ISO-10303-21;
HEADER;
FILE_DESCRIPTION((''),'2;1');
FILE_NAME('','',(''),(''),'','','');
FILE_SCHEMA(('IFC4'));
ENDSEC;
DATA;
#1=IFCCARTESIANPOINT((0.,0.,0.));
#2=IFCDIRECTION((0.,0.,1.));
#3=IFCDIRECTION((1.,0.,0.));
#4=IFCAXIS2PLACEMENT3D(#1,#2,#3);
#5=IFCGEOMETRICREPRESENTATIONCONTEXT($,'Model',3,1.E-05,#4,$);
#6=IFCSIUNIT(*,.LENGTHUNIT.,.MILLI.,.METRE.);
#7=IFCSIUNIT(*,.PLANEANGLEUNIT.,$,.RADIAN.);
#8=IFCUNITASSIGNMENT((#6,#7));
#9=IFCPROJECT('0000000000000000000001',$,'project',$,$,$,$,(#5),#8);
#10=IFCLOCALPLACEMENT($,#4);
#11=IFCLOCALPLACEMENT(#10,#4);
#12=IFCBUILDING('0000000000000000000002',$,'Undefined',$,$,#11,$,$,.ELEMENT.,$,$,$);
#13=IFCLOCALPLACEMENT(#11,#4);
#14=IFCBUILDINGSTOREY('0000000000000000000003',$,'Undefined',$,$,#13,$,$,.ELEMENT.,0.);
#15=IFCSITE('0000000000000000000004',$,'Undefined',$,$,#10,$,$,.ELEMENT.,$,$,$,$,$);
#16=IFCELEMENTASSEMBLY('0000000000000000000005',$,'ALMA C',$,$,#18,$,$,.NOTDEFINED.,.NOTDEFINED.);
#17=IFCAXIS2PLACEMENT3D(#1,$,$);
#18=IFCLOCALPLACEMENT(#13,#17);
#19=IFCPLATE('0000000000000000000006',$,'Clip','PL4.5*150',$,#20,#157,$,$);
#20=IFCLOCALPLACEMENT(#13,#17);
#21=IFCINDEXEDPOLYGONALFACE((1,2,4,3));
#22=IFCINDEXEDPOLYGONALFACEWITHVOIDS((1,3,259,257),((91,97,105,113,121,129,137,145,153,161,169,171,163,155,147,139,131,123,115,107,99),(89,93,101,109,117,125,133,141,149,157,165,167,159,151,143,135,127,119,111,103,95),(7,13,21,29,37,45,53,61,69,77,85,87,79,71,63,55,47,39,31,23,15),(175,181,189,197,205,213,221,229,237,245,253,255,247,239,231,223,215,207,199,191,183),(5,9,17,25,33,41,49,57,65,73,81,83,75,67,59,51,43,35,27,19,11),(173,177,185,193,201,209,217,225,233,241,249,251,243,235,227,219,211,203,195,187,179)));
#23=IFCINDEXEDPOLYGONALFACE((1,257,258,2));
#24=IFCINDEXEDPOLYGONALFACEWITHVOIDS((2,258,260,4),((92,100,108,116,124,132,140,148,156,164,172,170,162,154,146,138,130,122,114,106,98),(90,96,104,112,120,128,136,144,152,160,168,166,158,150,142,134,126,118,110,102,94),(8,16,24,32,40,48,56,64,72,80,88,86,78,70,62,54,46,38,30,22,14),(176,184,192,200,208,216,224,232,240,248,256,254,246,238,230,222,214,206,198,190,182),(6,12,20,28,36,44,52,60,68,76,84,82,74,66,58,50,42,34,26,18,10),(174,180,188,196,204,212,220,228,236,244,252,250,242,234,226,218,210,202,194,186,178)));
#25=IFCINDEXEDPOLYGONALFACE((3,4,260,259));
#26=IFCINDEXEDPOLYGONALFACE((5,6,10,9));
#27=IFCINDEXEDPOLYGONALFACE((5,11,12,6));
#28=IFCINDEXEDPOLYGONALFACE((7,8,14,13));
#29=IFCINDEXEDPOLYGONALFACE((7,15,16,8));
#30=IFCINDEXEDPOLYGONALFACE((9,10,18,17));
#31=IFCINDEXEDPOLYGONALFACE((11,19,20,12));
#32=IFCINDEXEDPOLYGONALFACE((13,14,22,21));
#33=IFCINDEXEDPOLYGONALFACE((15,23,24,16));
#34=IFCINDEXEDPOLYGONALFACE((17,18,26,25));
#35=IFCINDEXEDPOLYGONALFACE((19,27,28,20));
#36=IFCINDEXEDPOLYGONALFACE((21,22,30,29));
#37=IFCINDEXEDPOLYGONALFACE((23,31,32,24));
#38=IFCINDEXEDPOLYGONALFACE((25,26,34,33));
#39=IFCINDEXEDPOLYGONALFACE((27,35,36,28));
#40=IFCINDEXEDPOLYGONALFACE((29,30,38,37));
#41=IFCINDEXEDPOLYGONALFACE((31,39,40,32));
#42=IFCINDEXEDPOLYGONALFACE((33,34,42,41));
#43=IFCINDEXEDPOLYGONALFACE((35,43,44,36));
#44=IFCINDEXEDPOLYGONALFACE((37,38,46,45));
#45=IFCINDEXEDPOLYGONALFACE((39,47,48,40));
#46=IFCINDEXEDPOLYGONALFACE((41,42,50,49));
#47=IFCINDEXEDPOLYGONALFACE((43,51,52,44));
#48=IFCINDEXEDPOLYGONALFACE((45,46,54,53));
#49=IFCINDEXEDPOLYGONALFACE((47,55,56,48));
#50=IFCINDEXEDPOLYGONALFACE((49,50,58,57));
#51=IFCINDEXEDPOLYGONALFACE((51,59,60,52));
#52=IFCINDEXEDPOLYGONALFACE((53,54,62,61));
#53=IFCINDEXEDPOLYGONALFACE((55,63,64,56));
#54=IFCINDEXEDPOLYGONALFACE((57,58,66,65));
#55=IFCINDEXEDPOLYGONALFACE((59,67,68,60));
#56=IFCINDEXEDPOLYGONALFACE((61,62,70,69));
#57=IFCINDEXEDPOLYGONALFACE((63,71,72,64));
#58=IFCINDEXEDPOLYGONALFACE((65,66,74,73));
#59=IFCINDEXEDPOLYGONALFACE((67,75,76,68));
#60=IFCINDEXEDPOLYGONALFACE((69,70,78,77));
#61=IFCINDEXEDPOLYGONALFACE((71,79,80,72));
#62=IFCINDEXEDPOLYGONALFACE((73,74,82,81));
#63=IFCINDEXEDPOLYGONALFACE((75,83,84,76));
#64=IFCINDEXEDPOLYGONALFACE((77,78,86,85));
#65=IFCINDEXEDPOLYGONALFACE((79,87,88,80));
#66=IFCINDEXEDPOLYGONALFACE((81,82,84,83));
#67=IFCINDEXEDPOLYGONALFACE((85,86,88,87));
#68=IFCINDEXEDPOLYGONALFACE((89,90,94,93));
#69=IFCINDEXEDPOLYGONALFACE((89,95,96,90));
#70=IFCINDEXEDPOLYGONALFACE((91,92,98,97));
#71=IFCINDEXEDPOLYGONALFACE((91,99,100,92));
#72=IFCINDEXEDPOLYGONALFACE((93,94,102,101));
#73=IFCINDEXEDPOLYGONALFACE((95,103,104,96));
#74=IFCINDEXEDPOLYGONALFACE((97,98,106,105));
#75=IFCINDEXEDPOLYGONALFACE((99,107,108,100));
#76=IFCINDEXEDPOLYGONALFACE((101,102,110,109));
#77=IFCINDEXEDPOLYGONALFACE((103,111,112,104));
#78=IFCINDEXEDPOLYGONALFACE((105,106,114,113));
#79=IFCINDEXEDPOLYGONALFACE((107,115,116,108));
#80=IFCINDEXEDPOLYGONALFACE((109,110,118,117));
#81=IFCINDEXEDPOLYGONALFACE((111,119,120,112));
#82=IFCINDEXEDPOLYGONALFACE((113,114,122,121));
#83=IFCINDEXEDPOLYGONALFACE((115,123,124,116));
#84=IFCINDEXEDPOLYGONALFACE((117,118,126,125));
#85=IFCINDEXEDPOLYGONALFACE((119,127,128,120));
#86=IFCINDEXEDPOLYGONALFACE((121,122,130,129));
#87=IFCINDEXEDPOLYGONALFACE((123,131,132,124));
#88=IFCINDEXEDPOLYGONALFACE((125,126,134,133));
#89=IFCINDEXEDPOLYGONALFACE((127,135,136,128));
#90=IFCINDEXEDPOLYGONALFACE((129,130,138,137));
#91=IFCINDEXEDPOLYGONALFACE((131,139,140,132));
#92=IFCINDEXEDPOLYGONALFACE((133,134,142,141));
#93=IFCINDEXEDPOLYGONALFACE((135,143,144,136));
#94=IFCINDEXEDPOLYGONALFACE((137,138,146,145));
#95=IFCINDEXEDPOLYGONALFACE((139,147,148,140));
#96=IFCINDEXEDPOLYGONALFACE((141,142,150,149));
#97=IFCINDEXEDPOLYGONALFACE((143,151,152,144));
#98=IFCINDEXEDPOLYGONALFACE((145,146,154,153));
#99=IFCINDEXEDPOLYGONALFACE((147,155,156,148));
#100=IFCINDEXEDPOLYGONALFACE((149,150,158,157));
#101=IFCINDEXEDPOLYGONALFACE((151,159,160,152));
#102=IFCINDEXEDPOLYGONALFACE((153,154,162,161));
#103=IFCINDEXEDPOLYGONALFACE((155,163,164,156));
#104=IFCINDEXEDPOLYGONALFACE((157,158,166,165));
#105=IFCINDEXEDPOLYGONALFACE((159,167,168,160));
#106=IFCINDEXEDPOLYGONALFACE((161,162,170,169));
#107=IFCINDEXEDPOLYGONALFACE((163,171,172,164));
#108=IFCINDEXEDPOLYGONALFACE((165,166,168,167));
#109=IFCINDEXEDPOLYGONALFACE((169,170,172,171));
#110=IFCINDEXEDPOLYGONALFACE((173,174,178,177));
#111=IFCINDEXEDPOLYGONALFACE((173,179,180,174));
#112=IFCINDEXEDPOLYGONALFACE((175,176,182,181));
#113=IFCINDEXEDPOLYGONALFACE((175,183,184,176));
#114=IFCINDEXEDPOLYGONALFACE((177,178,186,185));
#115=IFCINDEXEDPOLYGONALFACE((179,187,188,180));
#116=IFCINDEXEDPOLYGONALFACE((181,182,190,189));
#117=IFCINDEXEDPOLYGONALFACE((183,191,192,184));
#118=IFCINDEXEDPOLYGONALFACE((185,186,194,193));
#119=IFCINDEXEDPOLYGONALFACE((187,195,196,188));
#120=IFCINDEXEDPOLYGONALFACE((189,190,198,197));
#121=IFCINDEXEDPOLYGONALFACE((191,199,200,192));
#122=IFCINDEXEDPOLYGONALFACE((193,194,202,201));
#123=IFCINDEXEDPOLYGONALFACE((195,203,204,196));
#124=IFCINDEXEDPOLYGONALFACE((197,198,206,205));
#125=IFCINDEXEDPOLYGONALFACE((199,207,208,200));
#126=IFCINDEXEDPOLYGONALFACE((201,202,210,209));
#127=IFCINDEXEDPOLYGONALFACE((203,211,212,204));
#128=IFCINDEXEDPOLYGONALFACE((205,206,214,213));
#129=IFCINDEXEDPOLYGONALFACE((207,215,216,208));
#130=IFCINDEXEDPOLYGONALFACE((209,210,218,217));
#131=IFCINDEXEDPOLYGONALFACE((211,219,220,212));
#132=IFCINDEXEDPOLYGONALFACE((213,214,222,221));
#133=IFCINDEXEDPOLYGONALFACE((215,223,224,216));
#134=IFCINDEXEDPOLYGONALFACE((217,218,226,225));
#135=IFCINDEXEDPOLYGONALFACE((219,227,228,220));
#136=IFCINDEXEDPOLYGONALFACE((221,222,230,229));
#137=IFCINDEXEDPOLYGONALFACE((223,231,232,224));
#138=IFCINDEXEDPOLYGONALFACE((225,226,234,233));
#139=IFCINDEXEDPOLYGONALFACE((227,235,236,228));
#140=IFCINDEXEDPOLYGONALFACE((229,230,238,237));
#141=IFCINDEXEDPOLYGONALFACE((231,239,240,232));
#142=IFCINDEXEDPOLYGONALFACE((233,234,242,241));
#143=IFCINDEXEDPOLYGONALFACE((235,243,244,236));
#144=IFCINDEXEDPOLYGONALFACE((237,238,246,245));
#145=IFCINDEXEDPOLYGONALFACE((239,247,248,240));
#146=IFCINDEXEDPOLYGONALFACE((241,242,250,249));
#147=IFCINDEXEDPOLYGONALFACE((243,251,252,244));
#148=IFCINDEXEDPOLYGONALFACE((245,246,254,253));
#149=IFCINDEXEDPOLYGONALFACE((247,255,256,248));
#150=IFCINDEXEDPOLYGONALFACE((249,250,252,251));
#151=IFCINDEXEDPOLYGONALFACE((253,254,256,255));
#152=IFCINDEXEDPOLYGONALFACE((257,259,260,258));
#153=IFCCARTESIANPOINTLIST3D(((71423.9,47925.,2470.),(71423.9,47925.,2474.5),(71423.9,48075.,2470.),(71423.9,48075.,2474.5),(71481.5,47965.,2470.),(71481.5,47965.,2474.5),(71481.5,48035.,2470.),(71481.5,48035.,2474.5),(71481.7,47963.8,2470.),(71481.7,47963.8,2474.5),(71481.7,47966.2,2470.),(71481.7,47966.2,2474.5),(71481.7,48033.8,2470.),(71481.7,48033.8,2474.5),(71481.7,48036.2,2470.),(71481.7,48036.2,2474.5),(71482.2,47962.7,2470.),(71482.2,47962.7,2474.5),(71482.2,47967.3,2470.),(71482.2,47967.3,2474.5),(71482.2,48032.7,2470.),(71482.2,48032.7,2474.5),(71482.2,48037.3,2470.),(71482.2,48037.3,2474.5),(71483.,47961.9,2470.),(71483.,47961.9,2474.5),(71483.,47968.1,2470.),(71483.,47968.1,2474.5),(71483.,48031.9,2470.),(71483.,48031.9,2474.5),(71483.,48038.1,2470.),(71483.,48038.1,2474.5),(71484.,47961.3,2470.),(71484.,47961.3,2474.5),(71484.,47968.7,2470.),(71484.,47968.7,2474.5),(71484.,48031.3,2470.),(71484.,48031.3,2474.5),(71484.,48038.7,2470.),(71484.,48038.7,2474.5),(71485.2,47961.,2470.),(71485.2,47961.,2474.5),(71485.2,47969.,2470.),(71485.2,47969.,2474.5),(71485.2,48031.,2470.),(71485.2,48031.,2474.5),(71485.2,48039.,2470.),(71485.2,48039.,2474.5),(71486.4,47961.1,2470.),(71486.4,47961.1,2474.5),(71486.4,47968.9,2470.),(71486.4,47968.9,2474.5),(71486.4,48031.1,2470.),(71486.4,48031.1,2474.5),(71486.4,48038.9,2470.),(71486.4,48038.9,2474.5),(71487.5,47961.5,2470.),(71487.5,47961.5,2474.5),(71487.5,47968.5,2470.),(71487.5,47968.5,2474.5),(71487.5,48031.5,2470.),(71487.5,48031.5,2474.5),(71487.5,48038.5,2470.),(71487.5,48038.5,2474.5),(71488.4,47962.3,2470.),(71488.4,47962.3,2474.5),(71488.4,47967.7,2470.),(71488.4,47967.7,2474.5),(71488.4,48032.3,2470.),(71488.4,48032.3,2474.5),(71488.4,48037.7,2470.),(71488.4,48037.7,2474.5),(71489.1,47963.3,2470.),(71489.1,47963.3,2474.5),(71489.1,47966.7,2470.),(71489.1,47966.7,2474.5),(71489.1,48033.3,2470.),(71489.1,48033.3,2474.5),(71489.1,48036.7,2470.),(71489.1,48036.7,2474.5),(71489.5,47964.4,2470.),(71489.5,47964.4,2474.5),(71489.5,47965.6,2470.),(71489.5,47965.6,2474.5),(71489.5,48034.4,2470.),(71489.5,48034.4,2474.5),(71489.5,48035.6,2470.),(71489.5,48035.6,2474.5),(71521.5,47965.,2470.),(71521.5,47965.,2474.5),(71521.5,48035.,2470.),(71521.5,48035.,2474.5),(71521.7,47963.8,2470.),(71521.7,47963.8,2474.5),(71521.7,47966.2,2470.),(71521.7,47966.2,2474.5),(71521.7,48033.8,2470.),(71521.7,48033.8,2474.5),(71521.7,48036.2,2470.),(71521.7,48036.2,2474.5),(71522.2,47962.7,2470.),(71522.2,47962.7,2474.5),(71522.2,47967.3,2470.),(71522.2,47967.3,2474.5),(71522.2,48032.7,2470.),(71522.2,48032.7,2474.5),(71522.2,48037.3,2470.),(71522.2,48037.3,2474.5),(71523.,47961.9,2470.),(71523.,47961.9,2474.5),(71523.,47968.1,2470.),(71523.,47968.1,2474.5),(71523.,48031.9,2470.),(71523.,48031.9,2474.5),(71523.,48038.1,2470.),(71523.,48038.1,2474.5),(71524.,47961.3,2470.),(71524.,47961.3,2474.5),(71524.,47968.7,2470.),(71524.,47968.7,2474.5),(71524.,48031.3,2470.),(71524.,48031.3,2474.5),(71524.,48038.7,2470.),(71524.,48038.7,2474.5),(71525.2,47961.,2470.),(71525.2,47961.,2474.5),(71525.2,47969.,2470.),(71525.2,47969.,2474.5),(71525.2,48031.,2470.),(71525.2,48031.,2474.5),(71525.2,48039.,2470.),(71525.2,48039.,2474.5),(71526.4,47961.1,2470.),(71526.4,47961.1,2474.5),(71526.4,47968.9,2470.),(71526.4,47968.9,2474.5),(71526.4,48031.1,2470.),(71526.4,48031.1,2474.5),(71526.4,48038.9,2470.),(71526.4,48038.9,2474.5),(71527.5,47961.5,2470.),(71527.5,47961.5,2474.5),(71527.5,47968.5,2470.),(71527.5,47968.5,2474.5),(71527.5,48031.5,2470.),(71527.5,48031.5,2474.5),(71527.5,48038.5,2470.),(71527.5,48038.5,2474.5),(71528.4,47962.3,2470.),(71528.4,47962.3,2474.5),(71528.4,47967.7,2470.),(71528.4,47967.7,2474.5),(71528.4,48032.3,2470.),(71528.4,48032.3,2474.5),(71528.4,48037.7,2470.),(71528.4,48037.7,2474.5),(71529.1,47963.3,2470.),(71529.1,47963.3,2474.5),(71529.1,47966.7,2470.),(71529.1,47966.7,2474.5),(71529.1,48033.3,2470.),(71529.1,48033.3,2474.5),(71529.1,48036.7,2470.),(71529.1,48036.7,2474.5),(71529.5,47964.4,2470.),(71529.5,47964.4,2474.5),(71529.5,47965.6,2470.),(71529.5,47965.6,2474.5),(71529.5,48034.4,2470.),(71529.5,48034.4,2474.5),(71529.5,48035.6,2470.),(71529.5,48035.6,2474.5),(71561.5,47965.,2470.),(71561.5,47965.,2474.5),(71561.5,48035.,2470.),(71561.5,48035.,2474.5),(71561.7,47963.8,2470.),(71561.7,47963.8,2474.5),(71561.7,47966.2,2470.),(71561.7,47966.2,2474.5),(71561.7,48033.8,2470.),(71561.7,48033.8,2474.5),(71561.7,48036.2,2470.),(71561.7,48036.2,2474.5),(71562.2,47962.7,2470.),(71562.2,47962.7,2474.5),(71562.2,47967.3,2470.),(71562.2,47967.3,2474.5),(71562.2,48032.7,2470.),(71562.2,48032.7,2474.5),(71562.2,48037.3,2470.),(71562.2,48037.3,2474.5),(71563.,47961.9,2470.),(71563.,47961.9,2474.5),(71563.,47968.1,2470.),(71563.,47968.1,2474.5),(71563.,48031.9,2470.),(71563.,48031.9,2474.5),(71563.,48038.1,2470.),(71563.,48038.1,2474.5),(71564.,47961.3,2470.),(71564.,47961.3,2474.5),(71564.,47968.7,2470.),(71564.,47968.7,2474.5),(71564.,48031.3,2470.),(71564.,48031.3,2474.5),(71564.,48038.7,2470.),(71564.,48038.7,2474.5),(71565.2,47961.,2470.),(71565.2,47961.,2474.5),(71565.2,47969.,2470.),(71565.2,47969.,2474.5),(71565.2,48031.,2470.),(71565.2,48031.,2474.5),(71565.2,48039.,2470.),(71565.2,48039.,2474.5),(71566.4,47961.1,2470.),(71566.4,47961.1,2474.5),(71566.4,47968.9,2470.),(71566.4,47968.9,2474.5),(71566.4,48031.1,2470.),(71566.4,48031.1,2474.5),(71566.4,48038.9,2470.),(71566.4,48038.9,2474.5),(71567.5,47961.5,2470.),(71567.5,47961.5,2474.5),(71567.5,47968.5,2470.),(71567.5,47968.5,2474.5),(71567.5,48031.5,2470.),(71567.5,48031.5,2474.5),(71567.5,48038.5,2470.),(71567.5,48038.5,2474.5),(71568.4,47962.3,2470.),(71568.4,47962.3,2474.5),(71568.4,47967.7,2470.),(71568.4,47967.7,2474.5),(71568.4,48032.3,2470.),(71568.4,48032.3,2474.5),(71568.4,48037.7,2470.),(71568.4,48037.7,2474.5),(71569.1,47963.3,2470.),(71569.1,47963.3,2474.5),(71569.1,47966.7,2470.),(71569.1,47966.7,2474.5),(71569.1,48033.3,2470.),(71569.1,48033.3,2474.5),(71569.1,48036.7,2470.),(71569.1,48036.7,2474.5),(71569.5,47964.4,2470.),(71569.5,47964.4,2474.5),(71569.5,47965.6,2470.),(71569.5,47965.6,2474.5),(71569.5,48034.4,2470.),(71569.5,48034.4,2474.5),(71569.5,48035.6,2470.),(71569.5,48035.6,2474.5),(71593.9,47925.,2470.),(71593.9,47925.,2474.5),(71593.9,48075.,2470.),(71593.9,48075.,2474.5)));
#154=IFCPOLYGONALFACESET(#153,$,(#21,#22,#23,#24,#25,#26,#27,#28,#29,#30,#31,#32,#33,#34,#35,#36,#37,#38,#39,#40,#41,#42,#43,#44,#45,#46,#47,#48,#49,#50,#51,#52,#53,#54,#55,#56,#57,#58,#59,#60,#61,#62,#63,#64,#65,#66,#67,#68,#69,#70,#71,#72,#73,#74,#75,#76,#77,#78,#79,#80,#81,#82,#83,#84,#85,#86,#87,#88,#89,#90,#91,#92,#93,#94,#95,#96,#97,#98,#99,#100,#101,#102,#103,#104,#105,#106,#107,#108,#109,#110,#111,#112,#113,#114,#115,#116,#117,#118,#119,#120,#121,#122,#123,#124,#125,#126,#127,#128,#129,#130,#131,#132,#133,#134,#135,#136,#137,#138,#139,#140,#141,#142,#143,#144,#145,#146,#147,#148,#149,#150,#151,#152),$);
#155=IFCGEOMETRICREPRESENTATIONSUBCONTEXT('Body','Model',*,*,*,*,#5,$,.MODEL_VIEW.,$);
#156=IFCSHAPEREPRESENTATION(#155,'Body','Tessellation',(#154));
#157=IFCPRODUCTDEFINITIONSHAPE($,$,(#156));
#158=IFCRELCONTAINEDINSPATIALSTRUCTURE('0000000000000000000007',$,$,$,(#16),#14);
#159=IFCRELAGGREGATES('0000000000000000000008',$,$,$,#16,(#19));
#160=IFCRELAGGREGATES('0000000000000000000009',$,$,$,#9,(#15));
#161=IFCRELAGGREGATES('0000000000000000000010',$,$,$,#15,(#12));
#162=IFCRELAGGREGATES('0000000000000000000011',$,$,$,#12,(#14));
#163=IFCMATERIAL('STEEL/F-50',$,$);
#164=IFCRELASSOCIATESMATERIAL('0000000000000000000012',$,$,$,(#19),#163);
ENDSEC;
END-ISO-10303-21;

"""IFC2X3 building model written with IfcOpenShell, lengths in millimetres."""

from ifc_helpers import new_model, si_unit, frame, origin_with_axes, origin_2d_with_axis, place, context, subcontext, project, spatial, polyline, circle, outline, extrude, source, transform, mapped, material, element, aggregate, save


model = new_model("IFC2X3")

# Units and contexts
model_context = context("Model", 3, precision=1e-05, world=origin_with_axes())
body_context = subcontext(model_context, "Body", "Model", "MODEL_VIEW")
ifc_project = project(units=[si_unit("LENGTHUNIT", "METRE", prefix="MILLI"), si_unit("PLANEANGLEUNIT", "RADIAN")], contexts=[model_context])

# Site, building, storey
site_placement = place(None, origin_with_axes())
site = spatial("IfcSite", under=ifc_project, at=site_placement, Name="Undefined", CompositionType="ELEMENT")
building_placement = place(site_placement, origin_with_axes())
building = spatial("IfcBuilding", under=site, at=building_placement, Name="Undefined", CompositionType="ELEMENT")
storey_placement = place(building_placement, origin_with_axes())
storey = spatial("IfcBuildingStorey", under=building, at=storey_placement, Name="Undefined", CompositionType="ELEMENT", Elevation=0.0)

# Element assembly
assembly_1_placement = place(storey_placement, origin_with_axes())
assembly_1 = element("IfcElementAssembly", 1, at=assembly_1_placement, inside=storey, Name="ALMA C", AssemblyPlace="NOTDEFINED", PredefinedType="NOTDEFINED")
ifc_material_1 = material(Name="STEEL/F-50")

# Plate, openings
shared_shape_1 = source(origin_with_axes(), body_context, "Body", "SweptSolid", [
    extrude(circle(Radius=4.0, at=origin_2d_with_axis()), frame((0.0, -4.6, 0.0), z_axis=(0.0, 1.0, 0.0), x_axis=(1.0, 0.0, 0.0)), (0.0, 0.0, 1.0), 4.7),
])
plate_1_placement = place(assembly_1_placement, frame((71423.9, 48075.0, 2472.2), z_axis=(0.0, 0.0, -1.0), x_axis=(1.0, 0.0, 0.0)))
plate_1 = element("IfcPlate", 2, at=plate_1_placement, material=ifc_material_1, Name="Clip", Description="PL4.5*150", context=body_context, shape_type="SweptSolid", body=[
    extrude(outline(polyline([(0.0, 0.0), (170.0, 0.0), (170.0, 150.0), (0.0, 150.0), (0.0, 0.0)])), frame((0.0, 0.0, -2.2), z_axis=(0.0, 0.0, 1.0), x_axis=(1.0, 0.0, 0.0)), (0.0, 0.0, 1.0), 4.5),
])
opening_1_placement = place(assembly_1_placement, frame((71565.5, 47965.0, 2470.0), z_axis=(0.0, -1.0, 0.0), x_axis=(-1.0, 0.0, 0.0)))
element("IfcOpeningElement", 3, at=opening_1_placement, cuts=plate_1, ObjectType="Opening", context=body_context, shape_type="MappedRepresentation", body=[
    mapped(shared_shape_1, transform((0.0, 0.0, 0.0))),
    mapped(shared_shape_1, transform((40.0, 0.0, 0.0))),
    mapped(shared_shape_1, transform((80.0, 0.0, 0.0))),
])
opening_2_placement = place(assembly_1_placement, frame((71565.5, 48035.0, 2470.0), z_axis=(0.0, -1.0, 0.0), x_axis=(-1.0, 0.0, 0.0)))
element("IfcOpeningElement", 4, at=opening_2_placement, cuts=plate_1, ObjectType="Opening", context=body_context, shape_type="MappedRepresentation", body=[
    mapped(shared_shape_1, transform((0.0, 0.0, 0.0))),
    mapped(shared_shape_1, transform((40.0, 0.0, 0.0))),
    mapped(shared_shape_1, transform((80.0, 0.0, 0.0))),
])

aggregate(assembly_1, [plate_1])

save(model, "model.ifc")
